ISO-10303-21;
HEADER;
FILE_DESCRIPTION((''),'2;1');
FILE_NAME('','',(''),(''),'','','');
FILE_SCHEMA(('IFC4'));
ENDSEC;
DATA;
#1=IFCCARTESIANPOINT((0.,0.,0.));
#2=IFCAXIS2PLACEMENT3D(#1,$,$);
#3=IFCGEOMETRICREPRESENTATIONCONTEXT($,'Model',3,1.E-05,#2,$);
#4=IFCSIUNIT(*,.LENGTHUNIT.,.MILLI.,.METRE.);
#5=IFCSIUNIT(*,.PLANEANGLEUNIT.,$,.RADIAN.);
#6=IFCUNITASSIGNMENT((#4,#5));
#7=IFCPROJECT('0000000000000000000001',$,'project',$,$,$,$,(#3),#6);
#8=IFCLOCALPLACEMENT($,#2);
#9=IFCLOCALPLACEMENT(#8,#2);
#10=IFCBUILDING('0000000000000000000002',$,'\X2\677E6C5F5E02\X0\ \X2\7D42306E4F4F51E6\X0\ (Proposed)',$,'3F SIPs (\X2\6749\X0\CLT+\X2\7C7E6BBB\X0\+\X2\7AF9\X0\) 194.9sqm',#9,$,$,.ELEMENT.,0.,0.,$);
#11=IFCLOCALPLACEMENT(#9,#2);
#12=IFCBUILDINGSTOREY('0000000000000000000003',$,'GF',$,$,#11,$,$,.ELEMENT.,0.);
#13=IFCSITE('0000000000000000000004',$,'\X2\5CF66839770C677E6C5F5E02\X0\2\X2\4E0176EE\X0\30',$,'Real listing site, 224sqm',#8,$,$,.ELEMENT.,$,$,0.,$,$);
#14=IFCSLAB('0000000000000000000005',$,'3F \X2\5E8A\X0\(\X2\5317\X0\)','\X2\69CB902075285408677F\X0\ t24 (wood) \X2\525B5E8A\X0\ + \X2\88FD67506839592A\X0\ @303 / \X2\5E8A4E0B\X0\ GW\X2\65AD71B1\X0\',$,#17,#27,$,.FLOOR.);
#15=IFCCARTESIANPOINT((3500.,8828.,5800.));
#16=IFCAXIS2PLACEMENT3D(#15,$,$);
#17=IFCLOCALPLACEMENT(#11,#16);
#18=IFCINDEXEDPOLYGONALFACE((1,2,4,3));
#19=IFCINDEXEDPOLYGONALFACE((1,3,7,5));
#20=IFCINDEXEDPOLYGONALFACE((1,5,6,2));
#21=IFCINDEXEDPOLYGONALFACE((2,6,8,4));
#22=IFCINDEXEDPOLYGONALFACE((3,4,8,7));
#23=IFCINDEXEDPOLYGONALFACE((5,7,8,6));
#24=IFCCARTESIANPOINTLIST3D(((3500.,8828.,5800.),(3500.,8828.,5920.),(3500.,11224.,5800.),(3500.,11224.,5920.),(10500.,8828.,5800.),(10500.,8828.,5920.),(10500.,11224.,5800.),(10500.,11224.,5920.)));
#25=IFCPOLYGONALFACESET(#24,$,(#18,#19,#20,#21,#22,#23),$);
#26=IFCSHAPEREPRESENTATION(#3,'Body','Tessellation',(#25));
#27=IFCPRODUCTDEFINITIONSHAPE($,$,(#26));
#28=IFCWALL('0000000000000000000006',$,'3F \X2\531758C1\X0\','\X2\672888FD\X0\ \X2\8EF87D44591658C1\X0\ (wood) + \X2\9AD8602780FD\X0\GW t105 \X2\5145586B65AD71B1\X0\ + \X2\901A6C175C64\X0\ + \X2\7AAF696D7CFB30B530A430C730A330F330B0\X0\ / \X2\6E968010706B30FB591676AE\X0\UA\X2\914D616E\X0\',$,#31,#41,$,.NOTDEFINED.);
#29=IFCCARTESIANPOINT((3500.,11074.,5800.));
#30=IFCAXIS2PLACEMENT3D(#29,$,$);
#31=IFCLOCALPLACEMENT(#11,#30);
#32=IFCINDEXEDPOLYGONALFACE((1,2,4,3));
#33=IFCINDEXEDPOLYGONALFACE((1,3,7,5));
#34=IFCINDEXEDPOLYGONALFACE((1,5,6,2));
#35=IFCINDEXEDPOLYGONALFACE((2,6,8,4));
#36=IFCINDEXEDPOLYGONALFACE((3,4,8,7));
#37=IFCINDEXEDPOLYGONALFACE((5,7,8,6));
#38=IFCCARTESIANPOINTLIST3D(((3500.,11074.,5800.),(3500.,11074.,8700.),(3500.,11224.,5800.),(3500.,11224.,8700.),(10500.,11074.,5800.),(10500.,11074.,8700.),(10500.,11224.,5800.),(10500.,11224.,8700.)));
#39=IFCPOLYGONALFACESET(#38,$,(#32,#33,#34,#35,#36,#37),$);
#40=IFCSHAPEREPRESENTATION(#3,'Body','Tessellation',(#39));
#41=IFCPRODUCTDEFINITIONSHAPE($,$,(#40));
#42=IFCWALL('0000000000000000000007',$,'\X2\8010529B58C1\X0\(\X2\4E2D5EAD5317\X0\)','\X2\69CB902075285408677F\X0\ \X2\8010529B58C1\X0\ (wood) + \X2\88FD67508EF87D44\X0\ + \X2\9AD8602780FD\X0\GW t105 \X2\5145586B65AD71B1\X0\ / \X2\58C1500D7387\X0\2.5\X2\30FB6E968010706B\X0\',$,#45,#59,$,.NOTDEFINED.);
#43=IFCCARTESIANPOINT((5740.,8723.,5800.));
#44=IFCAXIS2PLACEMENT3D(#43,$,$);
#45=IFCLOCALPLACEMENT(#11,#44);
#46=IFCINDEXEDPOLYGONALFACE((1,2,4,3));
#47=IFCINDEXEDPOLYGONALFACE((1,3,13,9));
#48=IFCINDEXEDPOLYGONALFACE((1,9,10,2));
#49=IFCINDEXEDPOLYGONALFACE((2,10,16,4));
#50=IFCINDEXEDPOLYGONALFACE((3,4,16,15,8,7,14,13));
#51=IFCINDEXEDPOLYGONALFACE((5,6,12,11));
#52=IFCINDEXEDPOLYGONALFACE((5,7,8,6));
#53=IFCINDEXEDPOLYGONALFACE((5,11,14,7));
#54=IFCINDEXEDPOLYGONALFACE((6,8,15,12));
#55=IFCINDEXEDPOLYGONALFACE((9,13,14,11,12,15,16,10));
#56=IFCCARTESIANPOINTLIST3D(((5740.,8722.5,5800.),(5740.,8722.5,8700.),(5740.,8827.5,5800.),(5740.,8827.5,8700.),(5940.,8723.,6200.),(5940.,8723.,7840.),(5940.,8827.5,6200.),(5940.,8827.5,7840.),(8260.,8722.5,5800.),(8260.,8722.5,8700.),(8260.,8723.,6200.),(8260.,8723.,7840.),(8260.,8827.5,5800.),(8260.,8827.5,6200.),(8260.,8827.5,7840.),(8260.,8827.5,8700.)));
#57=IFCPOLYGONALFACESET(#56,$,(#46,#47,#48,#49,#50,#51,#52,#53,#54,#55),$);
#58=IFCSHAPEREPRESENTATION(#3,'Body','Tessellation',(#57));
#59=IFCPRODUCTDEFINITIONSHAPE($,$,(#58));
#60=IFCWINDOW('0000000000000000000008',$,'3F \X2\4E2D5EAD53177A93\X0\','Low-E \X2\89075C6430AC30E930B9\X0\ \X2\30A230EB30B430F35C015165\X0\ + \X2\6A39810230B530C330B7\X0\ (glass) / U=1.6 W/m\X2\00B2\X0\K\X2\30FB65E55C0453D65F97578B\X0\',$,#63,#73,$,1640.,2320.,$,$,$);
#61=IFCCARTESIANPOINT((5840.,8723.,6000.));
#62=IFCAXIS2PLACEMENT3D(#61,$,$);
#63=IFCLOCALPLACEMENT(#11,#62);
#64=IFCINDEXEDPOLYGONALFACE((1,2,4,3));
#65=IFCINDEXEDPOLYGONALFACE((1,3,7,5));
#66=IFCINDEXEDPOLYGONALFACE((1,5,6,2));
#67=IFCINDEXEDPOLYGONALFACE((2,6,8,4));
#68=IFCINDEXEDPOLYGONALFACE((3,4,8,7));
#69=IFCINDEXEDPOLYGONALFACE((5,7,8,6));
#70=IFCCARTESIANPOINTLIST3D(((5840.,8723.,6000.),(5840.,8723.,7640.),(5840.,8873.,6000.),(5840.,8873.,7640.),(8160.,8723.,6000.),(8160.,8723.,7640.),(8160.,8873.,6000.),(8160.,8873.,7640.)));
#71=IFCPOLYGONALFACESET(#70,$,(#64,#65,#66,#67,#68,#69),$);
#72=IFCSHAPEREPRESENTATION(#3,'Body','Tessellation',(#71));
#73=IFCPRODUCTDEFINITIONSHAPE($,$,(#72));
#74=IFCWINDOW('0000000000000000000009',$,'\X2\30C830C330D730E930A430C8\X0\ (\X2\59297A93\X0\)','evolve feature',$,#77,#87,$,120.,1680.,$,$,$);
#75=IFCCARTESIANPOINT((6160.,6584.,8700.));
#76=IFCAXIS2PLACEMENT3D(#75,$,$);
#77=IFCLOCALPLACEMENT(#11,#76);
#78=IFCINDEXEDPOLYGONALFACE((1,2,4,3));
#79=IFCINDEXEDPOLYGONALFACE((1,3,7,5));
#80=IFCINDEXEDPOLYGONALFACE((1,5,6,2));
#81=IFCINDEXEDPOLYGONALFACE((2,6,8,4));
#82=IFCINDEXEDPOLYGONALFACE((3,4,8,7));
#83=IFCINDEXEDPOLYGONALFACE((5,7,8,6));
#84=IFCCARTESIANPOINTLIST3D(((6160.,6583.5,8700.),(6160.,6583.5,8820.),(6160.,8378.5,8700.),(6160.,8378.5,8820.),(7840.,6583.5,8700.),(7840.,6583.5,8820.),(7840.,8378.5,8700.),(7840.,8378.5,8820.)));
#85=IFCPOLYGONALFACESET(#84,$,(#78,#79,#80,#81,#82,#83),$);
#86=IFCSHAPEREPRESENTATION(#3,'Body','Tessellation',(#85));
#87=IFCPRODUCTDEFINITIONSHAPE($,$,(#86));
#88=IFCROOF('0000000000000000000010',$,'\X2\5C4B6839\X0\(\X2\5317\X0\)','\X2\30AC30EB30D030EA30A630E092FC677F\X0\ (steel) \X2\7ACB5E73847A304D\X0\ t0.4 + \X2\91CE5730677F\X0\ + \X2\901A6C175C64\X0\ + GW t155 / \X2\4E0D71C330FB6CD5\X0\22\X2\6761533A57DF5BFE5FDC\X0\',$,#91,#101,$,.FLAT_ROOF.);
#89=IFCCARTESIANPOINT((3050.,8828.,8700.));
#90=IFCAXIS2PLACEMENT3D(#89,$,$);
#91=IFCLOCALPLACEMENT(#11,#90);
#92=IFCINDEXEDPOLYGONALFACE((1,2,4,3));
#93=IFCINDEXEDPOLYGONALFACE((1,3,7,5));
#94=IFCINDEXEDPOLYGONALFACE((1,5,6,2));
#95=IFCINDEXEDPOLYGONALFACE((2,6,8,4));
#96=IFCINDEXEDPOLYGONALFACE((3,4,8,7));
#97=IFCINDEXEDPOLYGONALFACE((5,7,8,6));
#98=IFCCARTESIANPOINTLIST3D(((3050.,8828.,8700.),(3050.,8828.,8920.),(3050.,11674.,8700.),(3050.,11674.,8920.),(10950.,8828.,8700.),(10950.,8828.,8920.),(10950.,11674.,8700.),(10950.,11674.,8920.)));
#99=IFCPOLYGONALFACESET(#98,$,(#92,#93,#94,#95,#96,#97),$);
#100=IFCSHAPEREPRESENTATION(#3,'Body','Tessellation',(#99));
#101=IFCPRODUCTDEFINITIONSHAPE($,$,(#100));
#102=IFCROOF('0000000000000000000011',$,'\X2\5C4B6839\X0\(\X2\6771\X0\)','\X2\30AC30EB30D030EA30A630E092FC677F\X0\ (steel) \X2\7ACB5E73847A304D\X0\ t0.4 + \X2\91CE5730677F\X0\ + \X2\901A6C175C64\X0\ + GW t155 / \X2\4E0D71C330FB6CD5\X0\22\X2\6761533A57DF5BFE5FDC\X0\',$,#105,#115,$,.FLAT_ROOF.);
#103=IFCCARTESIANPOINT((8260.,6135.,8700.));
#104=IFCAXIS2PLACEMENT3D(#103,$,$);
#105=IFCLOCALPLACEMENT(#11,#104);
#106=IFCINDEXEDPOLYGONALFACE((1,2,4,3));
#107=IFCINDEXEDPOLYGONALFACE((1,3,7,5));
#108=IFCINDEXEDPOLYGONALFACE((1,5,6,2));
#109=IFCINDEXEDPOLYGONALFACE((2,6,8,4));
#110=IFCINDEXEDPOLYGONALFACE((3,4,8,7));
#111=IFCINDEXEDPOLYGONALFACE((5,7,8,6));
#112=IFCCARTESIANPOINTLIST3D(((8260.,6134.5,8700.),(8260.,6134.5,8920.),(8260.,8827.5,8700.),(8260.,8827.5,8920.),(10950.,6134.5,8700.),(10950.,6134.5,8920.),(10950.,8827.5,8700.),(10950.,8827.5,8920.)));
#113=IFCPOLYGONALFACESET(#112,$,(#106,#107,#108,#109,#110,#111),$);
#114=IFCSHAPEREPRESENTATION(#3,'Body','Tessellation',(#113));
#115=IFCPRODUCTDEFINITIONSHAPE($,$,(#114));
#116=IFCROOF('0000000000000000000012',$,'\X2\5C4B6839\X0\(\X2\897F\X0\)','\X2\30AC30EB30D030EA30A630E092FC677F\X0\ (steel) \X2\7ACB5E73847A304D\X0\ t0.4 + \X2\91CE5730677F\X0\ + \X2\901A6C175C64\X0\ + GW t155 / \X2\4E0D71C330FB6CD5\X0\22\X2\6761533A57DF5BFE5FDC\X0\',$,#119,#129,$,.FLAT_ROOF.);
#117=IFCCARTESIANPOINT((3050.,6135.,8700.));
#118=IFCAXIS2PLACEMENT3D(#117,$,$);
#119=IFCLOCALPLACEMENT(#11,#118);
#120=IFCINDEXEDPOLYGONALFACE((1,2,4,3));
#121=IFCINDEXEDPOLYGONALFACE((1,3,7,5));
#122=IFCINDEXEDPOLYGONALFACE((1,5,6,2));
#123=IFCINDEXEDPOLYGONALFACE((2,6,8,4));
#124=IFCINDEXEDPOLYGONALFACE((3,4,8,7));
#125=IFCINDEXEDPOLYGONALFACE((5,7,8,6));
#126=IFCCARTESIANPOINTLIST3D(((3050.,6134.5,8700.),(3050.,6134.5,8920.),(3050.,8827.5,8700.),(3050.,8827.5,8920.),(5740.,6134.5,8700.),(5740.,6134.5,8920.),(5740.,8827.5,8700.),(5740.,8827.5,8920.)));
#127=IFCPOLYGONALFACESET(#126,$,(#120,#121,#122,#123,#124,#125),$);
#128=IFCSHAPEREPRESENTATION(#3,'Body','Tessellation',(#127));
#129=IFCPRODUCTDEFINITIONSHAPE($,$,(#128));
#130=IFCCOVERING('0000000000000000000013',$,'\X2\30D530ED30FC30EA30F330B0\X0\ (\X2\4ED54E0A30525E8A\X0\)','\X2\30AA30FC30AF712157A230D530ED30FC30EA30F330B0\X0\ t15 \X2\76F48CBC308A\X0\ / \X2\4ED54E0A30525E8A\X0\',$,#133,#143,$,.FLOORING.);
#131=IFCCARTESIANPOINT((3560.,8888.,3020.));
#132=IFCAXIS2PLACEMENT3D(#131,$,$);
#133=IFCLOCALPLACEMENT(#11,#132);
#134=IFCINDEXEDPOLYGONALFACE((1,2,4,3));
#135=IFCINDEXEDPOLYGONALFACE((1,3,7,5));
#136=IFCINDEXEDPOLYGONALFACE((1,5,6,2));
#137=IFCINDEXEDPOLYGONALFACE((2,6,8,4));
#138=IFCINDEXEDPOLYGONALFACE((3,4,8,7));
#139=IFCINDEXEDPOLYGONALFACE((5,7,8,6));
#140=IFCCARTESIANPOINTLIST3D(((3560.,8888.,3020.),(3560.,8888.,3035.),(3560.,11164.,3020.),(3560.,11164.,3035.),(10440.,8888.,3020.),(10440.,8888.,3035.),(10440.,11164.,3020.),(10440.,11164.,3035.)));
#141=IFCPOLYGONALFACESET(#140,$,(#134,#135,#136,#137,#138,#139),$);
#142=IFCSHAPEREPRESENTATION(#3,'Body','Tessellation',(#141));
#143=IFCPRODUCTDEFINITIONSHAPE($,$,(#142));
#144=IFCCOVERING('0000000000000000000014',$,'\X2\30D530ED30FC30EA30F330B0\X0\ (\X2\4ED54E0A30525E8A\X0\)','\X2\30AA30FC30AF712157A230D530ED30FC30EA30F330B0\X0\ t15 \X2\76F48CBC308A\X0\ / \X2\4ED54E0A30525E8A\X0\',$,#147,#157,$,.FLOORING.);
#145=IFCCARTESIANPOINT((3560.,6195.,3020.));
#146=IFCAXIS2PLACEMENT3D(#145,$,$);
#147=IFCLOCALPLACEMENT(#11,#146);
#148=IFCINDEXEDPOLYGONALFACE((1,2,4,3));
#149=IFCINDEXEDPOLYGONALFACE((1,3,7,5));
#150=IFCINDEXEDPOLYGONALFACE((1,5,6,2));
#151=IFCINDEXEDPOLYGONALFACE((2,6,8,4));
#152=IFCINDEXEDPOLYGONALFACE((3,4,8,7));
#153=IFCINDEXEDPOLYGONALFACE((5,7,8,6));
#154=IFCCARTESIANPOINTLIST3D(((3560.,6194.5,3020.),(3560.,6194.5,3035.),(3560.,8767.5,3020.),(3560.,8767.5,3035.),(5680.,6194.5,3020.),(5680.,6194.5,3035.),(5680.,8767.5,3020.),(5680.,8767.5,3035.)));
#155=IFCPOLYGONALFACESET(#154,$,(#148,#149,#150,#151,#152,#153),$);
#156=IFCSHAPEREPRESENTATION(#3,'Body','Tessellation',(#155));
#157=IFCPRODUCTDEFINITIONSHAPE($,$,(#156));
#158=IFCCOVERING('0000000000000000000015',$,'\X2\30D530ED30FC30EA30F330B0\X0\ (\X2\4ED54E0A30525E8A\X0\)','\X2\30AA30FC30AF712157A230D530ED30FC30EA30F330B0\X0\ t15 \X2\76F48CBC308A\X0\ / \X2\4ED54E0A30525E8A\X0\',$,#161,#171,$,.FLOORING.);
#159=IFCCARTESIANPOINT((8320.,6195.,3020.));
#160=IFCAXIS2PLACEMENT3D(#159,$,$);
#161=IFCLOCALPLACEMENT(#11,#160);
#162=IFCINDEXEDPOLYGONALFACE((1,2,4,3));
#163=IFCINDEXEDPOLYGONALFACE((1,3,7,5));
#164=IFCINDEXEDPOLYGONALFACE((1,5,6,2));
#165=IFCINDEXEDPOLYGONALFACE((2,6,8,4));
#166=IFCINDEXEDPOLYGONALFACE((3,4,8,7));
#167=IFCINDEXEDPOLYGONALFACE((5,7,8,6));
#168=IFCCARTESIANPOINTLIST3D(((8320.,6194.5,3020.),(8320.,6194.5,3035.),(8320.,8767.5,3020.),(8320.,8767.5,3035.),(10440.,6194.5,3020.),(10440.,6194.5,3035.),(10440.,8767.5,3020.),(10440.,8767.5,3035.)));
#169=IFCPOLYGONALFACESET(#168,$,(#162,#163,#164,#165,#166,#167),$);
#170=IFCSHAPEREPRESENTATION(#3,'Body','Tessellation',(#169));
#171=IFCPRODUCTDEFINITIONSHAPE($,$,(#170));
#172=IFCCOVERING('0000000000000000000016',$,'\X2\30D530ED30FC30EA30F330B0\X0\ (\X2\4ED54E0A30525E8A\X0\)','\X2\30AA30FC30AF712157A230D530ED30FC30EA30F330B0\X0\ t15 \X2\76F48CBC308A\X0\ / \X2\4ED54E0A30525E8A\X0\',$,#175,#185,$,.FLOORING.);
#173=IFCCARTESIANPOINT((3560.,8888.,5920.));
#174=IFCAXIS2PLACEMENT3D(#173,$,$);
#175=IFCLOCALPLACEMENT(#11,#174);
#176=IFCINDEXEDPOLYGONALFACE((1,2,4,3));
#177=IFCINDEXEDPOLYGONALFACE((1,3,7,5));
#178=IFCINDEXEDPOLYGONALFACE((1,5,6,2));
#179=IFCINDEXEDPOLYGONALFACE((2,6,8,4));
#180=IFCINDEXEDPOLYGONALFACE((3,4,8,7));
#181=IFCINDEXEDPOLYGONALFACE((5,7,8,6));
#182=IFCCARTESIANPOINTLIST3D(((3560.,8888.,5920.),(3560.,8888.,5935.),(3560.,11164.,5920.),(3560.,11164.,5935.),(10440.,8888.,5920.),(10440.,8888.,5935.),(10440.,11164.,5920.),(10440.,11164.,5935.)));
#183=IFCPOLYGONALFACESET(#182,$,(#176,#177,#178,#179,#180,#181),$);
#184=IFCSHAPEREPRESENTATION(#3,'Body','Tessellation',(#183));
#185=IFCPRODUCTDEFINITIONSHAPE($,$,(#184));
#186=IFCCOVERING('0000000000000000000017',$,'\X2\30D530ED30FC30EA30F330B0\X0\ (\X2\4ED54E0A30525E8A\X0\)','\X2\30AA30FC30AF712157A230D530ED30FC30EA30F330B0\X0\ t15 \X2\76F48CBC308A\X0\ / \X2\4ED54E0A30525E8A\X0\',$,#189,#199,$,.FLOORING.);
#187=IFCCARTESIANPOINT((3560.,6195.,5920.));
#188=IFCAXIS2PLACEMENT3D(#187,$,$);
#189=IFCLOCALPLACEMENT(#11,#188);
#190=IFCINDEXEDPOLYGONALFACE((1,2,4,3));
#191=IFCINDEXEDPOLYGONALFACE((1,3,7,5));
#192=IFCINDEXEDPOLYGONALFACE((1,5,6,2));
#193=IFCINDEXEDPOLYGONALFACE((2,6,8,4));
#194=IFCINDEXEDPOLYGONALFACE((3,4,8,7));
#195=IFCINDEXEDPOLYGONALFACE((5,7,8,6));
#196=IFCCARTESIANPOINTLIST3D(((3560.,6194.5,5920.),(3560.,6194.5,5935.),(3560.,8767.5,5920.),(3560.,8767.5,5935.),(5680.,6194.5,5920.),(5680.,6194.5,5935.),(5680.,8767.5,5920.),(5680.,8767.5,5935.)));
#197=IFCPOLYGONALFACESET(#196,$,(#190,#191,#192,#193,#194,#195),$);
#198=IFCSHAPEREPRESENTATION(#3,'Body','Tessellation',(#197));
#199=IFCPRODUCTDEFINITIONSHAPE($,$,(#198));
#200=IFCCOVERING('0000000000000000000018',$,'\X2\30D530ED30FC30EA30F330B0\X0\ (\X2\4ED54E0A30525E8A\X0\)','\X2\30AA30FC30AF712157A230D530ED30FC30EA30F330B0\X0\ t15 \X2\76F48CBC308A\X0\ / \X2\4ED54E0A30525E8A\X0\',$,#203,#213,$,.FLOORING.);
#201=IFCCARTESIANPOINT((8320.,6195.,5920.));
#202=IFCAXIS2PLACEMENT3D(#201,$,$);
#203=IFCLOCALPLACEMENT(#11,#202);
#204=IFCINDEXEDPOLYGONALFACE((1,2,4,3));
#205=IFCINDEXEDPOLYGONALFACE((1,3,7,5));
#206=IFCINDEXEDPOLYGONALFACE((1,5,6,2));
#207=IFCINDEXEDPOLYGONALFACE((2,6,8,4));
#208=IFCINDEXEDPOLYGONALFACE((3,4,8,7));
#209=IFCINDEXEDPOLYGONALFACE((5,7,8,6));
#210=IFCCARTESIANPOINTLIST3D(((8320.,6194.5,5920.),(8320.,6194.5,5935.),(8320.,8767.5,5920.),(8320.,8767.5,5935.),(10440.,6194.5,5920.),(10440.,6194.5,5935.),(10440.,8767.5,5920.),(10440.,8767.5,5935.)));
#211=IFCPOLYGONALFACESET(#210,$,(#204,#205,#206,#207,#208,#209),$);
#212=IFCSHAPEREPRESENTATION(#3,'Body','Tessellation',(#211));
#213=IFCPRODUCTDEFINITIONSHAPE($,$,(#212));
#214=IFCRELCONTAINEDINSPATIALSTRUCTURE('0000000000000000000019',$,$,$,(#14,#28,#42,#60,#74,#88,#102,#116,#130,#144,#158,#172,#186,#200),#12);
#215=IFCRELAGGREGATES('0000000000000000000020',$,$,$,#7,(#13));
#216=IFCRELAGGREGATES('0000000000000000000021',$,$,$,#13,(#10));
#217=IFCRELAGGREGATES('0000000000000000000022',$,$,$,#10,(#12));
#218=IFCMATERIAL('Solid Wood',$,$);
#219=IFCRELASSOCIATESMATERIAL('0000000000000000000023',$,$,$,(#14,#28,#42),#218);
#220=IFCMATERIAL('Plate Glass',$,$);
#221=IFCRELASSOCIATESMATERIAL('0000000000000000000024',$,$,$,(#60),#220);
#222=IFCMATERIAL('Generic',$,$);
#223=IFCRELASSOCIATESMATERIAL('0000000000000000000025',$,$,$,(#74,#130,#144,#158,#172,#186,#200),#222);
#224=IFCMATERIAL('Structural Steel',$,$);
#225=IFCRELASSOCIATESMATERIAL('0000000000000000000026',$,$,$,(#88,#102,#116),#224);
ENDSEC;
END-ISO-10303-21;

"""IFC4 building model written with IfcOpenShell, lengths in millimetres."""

from ifc_helpers import new_model, si_unit, frame, frame_2d, origin, place, context, project, spatial, rectangle, extrude, material, element, fill, save


model = new_model("IFC4")

# Units and contexts
model_context = context("Model", 3, precision=1e-05, world=origin())
ifc_project = project(units=[si_unit("LENGTHUNIT", "METRE", prefix="MILLI"), si_unit("PLANEANGLEUNIT", "RADIAN")], contexts=[model_context])

# Site, building, storey
site_placement = place(None, origin())
site = spatial("IfcSite", under=ifc_project, at=site_placement, Name="島根県松江市2丁目30", ObjectType="Real listing site, 224sqm", CompositionType="ELEMENT", RefElevation=0.0)
building_placement = place(site_placement, origin())
building = spatial("IfcBuilding", under=site, at=building_placement, Name="松江市 終の住処 (Proposed)", ObjectType="3F SIPs (杉CLT+籾殻+竹) 194.9sqm", CompositionType="ELEMENT", ElevationOfRefHeight=0.0, ElevationOfTerrain=0.0)
storey_placement = place(building_placement, origin())
storey = spatial("IfcBuildingStorey", under=building, at=storey_placement, Name="GF", CompositionType="ELEMENT", Elevation=0.0)

# Slab
ifc_material_1 = material(Name="Solid Wood")
slab_placement = place(storey_placement, frame((3500.0, 8828.0, 5800.0)))
element("IfcSlab", 1, at=slab_placement, inside=storey, material=ifc_material_1, Name="3F 床(北)", Description="構造用合板 t24 (wood) 剛床 + 製材根太 @303 / 床下 GW断熱", PredefinedType="FLOOR", context=model_context, shape_type="SweptSolid", body=[
    extrude(rectangle(XDim=7000.0, YDim=2396.0, at=frame_2d((3500.0, 1198.0))), frame((3500.0, 8828.0, 5800.0)), (0.0, 0.0, 1.0), 120.0),
])

# Wall
wall_1_placement = place(storey_placement, frame((3500.0, 11074.0, 5800.0)))
element("IfcWall", 2, at=wall_1_placement, inside=storey, material=ifc_material_1, Name="3F 北壁", Description="木製 軸組外壁 (wood) + 高性能GW t105 充填断熱 + 通気層 + 窯業系サイディング / 準耐火・外皮UA配慮", PredefinedType="NOTDEFINED", context=model_context, shape_type="SweptSolid", body=[
    extrude(rectangle(XDim=7000.0, YDim=150.0, at=frame_2d((3500.0, 75.0))), frame((3500.0, 11074.0, 5800.0)), (0.0, 0.0, 1.0), 2900.0),
])

# Wall, opening, window
wall_2_placement = place(storey_placement, frame((5740.0, 8723.0, 5800.0)))
wall_2 = element("IfcWall", 3, at=wall_2_placement, inside=storey, material=ifc_material_1, Name="耐力壁(中庭北)", Description="構造用合板 耐力壁 (wood) + 製材軸組 + 高性能GW t105 充填断熱 / 壁倍率2.5・準耐火", PredefinedType="NOTDEFINED", context=model_context, shape_type="SweptSolid", body=[
    extrude(rectangle(XDim=2520.0, YDim=105.0, at=frame_2d((1260.0, 52.0))), frame((5740.0, 8723.0, 5800.0)), (0.0, 0.0, 1.0), 2900.0),
])
opening_placement = place(storey_placement, frame((5840.0, 8723.0, 6000.0)))
opening = element("IfcOpeningElement", 4, at=opening_placement, cuts=wall_2, PredefinedType="NOTDEFINED", context=model_context, shape_type="SweptSolid", body=[
    extrude(rectangle(XDim=2320.0, YDim=150.0, at=frame_2d((1160.0, 75.0))), frame((5840.0, 8723.0, 6000.0)), (0.0, 0.0, 1.0), 1640.0),
])
ifc_material_2 = material(Name="Plate Glass")
window_1_placement = place(storey_placement, frame((5840.0, 8723.0, 6000.0)))
window_1 = element("IfcWindow", 5, at=window_1_placement, inside=storey, material=ifc_material_2, Name="3F 中庭北窓", Description="Low-E 複層ガラス アルゴン封入 + 樹脂サッシ (glass) / U=1.6 W/m²K・日射取得型", OverallHeight=1640.0, OverallWidth=2320.0, context=model_context, shape_type="SweptSolid", body=[
    extrude(rectangle(XDim=2320.0, YDim=150.0, at=frame_2d((1160.0, 75.0))), frame((5840.0, 8723.0, 6000.0)), (0.0, 0.0, 1.0), 1640.0),
])
fill(opening, window_1)

# Window
ifc_material_3 = material(Name="Generic")
window_2_placement = place(storey_placement, frame((6160.0, 6584.0, 8700.0)))
element("IfcWindow", 6, at=window_2_placement, inside=storey, material=ifc_material_3, Name="トップライト (天窓)", Description="evolve feature", OverallHeight=120.0, OverallWidth=1680.0, context=model_context, shape_type="SweptSolid", body=[
    extrude(rectangle(XDim=1680.0, YDim=1795.0, at=frame_2d((840.0, 897.0))), frame((6160.0, 6584.0, 8700.0)), (0.0, 0.0, 1.0), 120.0),
])

# Roofs
ifc_material_4 = material(Name="Structural Steel")
roof_1_placement = place(storey_placement, frame((3050.0, 8828.0, 8700.0)))
element("IfcRoof", 7, at=roof_1_placement, inside=storey, material=ifc_material_4, Name="屋根(北)", Description="ガルバリウム鋼板 (steel) 立平葺き t0.4 + 野地板 + 通気層 + GW t155 / 不燃・法22条区域対応", PredefinedType="FLAT_ROOF", context=model_context, shape_type="SweptSolid", body=[
    extrude(rectangle(XDim=7900.0, YDim=2846.0, at=frame_2d((3950.0, 1423.0))), frame((3050.0, 8828.0, 8700.0)), (0.0, 0.0, 1.0), 220.0),
])
roof_2_placement = place(storey_placement, frame((8260.0, 6135.0, 8700.0)))
element("IfcRoof", 8, at=roof_2_placement, inside=storey, material=ifc_material_4, Name="屋根(東)", Description="ガルバリウム鋼板 (steel) 立平葺き t0.4 + 野地板 + 通気層 + GW t155 / 不燃・法22条区域対応", PredefinedType="FLAT_ROOF", context=model_context, shape_type="SweptSolid", body=[
    extrude(rectangle(XDim=2690.0, YDim=2693.0, at=frame_2d((1345.0, 1346.0))), frame((8260.0, 6135.0, 8700.0)), (0.0, 0.0, 1.0), 220.0),
])
roof_3_placement = place(storey_placement, frame((3050.0, 6135.0, 8700.0)))
element("IfcRoof", 9, at=roof_3_placement, inside=storey, material=ifc_material_4, Name="屋根(西)", Description="ガルバリウム鋼板 (steel) 立平葺き t0.4 + 野地板 + 通気層 + GW t155 / 不燃・法22条区域対応", PredefinedType="FLAT_ROOF", context=model_context, shape_type="SweptSolid", body=[
    extrude(rectangle(XDim=2690.0, YDim=2693.0, at=frame_2d((1345.0, 1346.0))), frame((3050.0, 6135.0, 8700.0)), (0.0, 0.0, 1.0), 220.0),
])

# Coverings
covering_1_placement = place(storey_placement, frame((3560.0, 8888.0, 3020.0)))
element("IfcCovering", 10, at=covering_1_placement, inside=storey, material=ifc_material_3, Name="フローリング (仕上げ床)", Description="オーク無垢フローリング t15 直貼り / 仕上げ床", PredefinedType="FLOORING", context=model_context, shape_type="SweptSolid", body=[
    extrude(rectangle(XDim=6880.0, YDim=2276.0, at=frame_2d((3440.0, 1138.0))), frame((3560.0, 8888.0, 3020.0)), (0.0, 0.0, 1.0), 15.0),
])
covering_2_placement = place(storey_placement, frame((3560.0, 6195.0, 3020.0)))
element("IfcCovering", 11, at=covering_2_placement, inside=storey, material=ifc_material_3, Name="フローリング (仕上げ床)", Description="オーク無垢フローリング t15 直貼り / 仕上げ床", PredefinedType="FLOORING", context=model_context, shape_type="SweptSolid", body=[
    extrude(rectangle(XDim=2120.0, YDim=2573.0, at=frame_2d((1060.0, 1286.0))), frame((3560.0, 6195.0, 3020.0)), (0.0, 0.0, 1.0), 15.0),
])
covering_3_placement = place(storey_placement, frame((8320.0, 6195.0, 3020.0)))
element("IfcCovering", 12, at=covering_3_placement, inside=storey, material=ifc_material_3, Name="フローリング (仕上げ床)", Description="オーク無垢フローリング t15 直貼り / 仕上げ床", PredefinedType="FLOORING", context=model_context, shape_type="SweptSolid", body=[
    extrude(rectangle(XDim=2120.0, YDim=2573.0, at=frame_2d((1060.0, 1286.0))), frame((8320.0, 6195.0, 3020.0)), (0.0, 0.0, 1.0), 15.0),
])
covering_4_placement = place(storey_placement, frame((3560.0, 8888.0, 5920.0)))
element("IfcCovering", 13, at=covering_4_placement, inside=storey, material=ifc_material_3, Name="フローリング (仕上げ床)", Description="オーク無垢フローリング t15 直貼り / 仕上げ床", PredefinedType="FLOORING", context=model_context, shape_type="SweptSolid", body=[
    extrude(rectangle(XDim=6880.0, YDim=2276.0, at=frame_2d((3440.0, 1138.0))), frame((3560.0, 8888.0, 5920.0)), (0.0, 0.0, 1.0), 15.0),
])
covering_5_placement = place(storey_placement, frame((3560.0, 6195.0, 5920.0)))
element("IfcCovering", 14, at=covering_5_placement, inside=storey, material=ifc_material_3, Name="フローリング (仕上げ床)", Description="オーク無垢フローリング t15 直貼り / 仕上げ床", PredefinedType="FLOORING", context=model_context, shape_type="SweptSolid", body=[
    extrude(rectangle(XDim=2120.0, YDim=2573.0, at=frame_2d((1060.0, 1286.0))), frame((3560.0, 6195.0, 5920.0)), (0.0, 0.0, 1.0), 15.0),
])
covering_6_placement = place(storey_placement, frame((8320.0, 6195.0, 5920.0)))
element("IfcCovering", 15, at=covering_6_placement, inside=storey, material=ifc_material_3, Name="フローリング (仕上げ床)", Description="オーク無垢フローリング t15 直貼り / 仕上げ床", PredefinedType="FLOORING", context=model_context, shape_type="SweptSolid", body=[
    extrude(rectangle(XDim=2120.0, YDim=2573.0, at=frame_2d((1060.0, 1286.0))), frame((8320.0, 6195.0, 5920.0)), (0.0, 0.0, 1.0), 15.0),
])

save(model, "model.ifc")
